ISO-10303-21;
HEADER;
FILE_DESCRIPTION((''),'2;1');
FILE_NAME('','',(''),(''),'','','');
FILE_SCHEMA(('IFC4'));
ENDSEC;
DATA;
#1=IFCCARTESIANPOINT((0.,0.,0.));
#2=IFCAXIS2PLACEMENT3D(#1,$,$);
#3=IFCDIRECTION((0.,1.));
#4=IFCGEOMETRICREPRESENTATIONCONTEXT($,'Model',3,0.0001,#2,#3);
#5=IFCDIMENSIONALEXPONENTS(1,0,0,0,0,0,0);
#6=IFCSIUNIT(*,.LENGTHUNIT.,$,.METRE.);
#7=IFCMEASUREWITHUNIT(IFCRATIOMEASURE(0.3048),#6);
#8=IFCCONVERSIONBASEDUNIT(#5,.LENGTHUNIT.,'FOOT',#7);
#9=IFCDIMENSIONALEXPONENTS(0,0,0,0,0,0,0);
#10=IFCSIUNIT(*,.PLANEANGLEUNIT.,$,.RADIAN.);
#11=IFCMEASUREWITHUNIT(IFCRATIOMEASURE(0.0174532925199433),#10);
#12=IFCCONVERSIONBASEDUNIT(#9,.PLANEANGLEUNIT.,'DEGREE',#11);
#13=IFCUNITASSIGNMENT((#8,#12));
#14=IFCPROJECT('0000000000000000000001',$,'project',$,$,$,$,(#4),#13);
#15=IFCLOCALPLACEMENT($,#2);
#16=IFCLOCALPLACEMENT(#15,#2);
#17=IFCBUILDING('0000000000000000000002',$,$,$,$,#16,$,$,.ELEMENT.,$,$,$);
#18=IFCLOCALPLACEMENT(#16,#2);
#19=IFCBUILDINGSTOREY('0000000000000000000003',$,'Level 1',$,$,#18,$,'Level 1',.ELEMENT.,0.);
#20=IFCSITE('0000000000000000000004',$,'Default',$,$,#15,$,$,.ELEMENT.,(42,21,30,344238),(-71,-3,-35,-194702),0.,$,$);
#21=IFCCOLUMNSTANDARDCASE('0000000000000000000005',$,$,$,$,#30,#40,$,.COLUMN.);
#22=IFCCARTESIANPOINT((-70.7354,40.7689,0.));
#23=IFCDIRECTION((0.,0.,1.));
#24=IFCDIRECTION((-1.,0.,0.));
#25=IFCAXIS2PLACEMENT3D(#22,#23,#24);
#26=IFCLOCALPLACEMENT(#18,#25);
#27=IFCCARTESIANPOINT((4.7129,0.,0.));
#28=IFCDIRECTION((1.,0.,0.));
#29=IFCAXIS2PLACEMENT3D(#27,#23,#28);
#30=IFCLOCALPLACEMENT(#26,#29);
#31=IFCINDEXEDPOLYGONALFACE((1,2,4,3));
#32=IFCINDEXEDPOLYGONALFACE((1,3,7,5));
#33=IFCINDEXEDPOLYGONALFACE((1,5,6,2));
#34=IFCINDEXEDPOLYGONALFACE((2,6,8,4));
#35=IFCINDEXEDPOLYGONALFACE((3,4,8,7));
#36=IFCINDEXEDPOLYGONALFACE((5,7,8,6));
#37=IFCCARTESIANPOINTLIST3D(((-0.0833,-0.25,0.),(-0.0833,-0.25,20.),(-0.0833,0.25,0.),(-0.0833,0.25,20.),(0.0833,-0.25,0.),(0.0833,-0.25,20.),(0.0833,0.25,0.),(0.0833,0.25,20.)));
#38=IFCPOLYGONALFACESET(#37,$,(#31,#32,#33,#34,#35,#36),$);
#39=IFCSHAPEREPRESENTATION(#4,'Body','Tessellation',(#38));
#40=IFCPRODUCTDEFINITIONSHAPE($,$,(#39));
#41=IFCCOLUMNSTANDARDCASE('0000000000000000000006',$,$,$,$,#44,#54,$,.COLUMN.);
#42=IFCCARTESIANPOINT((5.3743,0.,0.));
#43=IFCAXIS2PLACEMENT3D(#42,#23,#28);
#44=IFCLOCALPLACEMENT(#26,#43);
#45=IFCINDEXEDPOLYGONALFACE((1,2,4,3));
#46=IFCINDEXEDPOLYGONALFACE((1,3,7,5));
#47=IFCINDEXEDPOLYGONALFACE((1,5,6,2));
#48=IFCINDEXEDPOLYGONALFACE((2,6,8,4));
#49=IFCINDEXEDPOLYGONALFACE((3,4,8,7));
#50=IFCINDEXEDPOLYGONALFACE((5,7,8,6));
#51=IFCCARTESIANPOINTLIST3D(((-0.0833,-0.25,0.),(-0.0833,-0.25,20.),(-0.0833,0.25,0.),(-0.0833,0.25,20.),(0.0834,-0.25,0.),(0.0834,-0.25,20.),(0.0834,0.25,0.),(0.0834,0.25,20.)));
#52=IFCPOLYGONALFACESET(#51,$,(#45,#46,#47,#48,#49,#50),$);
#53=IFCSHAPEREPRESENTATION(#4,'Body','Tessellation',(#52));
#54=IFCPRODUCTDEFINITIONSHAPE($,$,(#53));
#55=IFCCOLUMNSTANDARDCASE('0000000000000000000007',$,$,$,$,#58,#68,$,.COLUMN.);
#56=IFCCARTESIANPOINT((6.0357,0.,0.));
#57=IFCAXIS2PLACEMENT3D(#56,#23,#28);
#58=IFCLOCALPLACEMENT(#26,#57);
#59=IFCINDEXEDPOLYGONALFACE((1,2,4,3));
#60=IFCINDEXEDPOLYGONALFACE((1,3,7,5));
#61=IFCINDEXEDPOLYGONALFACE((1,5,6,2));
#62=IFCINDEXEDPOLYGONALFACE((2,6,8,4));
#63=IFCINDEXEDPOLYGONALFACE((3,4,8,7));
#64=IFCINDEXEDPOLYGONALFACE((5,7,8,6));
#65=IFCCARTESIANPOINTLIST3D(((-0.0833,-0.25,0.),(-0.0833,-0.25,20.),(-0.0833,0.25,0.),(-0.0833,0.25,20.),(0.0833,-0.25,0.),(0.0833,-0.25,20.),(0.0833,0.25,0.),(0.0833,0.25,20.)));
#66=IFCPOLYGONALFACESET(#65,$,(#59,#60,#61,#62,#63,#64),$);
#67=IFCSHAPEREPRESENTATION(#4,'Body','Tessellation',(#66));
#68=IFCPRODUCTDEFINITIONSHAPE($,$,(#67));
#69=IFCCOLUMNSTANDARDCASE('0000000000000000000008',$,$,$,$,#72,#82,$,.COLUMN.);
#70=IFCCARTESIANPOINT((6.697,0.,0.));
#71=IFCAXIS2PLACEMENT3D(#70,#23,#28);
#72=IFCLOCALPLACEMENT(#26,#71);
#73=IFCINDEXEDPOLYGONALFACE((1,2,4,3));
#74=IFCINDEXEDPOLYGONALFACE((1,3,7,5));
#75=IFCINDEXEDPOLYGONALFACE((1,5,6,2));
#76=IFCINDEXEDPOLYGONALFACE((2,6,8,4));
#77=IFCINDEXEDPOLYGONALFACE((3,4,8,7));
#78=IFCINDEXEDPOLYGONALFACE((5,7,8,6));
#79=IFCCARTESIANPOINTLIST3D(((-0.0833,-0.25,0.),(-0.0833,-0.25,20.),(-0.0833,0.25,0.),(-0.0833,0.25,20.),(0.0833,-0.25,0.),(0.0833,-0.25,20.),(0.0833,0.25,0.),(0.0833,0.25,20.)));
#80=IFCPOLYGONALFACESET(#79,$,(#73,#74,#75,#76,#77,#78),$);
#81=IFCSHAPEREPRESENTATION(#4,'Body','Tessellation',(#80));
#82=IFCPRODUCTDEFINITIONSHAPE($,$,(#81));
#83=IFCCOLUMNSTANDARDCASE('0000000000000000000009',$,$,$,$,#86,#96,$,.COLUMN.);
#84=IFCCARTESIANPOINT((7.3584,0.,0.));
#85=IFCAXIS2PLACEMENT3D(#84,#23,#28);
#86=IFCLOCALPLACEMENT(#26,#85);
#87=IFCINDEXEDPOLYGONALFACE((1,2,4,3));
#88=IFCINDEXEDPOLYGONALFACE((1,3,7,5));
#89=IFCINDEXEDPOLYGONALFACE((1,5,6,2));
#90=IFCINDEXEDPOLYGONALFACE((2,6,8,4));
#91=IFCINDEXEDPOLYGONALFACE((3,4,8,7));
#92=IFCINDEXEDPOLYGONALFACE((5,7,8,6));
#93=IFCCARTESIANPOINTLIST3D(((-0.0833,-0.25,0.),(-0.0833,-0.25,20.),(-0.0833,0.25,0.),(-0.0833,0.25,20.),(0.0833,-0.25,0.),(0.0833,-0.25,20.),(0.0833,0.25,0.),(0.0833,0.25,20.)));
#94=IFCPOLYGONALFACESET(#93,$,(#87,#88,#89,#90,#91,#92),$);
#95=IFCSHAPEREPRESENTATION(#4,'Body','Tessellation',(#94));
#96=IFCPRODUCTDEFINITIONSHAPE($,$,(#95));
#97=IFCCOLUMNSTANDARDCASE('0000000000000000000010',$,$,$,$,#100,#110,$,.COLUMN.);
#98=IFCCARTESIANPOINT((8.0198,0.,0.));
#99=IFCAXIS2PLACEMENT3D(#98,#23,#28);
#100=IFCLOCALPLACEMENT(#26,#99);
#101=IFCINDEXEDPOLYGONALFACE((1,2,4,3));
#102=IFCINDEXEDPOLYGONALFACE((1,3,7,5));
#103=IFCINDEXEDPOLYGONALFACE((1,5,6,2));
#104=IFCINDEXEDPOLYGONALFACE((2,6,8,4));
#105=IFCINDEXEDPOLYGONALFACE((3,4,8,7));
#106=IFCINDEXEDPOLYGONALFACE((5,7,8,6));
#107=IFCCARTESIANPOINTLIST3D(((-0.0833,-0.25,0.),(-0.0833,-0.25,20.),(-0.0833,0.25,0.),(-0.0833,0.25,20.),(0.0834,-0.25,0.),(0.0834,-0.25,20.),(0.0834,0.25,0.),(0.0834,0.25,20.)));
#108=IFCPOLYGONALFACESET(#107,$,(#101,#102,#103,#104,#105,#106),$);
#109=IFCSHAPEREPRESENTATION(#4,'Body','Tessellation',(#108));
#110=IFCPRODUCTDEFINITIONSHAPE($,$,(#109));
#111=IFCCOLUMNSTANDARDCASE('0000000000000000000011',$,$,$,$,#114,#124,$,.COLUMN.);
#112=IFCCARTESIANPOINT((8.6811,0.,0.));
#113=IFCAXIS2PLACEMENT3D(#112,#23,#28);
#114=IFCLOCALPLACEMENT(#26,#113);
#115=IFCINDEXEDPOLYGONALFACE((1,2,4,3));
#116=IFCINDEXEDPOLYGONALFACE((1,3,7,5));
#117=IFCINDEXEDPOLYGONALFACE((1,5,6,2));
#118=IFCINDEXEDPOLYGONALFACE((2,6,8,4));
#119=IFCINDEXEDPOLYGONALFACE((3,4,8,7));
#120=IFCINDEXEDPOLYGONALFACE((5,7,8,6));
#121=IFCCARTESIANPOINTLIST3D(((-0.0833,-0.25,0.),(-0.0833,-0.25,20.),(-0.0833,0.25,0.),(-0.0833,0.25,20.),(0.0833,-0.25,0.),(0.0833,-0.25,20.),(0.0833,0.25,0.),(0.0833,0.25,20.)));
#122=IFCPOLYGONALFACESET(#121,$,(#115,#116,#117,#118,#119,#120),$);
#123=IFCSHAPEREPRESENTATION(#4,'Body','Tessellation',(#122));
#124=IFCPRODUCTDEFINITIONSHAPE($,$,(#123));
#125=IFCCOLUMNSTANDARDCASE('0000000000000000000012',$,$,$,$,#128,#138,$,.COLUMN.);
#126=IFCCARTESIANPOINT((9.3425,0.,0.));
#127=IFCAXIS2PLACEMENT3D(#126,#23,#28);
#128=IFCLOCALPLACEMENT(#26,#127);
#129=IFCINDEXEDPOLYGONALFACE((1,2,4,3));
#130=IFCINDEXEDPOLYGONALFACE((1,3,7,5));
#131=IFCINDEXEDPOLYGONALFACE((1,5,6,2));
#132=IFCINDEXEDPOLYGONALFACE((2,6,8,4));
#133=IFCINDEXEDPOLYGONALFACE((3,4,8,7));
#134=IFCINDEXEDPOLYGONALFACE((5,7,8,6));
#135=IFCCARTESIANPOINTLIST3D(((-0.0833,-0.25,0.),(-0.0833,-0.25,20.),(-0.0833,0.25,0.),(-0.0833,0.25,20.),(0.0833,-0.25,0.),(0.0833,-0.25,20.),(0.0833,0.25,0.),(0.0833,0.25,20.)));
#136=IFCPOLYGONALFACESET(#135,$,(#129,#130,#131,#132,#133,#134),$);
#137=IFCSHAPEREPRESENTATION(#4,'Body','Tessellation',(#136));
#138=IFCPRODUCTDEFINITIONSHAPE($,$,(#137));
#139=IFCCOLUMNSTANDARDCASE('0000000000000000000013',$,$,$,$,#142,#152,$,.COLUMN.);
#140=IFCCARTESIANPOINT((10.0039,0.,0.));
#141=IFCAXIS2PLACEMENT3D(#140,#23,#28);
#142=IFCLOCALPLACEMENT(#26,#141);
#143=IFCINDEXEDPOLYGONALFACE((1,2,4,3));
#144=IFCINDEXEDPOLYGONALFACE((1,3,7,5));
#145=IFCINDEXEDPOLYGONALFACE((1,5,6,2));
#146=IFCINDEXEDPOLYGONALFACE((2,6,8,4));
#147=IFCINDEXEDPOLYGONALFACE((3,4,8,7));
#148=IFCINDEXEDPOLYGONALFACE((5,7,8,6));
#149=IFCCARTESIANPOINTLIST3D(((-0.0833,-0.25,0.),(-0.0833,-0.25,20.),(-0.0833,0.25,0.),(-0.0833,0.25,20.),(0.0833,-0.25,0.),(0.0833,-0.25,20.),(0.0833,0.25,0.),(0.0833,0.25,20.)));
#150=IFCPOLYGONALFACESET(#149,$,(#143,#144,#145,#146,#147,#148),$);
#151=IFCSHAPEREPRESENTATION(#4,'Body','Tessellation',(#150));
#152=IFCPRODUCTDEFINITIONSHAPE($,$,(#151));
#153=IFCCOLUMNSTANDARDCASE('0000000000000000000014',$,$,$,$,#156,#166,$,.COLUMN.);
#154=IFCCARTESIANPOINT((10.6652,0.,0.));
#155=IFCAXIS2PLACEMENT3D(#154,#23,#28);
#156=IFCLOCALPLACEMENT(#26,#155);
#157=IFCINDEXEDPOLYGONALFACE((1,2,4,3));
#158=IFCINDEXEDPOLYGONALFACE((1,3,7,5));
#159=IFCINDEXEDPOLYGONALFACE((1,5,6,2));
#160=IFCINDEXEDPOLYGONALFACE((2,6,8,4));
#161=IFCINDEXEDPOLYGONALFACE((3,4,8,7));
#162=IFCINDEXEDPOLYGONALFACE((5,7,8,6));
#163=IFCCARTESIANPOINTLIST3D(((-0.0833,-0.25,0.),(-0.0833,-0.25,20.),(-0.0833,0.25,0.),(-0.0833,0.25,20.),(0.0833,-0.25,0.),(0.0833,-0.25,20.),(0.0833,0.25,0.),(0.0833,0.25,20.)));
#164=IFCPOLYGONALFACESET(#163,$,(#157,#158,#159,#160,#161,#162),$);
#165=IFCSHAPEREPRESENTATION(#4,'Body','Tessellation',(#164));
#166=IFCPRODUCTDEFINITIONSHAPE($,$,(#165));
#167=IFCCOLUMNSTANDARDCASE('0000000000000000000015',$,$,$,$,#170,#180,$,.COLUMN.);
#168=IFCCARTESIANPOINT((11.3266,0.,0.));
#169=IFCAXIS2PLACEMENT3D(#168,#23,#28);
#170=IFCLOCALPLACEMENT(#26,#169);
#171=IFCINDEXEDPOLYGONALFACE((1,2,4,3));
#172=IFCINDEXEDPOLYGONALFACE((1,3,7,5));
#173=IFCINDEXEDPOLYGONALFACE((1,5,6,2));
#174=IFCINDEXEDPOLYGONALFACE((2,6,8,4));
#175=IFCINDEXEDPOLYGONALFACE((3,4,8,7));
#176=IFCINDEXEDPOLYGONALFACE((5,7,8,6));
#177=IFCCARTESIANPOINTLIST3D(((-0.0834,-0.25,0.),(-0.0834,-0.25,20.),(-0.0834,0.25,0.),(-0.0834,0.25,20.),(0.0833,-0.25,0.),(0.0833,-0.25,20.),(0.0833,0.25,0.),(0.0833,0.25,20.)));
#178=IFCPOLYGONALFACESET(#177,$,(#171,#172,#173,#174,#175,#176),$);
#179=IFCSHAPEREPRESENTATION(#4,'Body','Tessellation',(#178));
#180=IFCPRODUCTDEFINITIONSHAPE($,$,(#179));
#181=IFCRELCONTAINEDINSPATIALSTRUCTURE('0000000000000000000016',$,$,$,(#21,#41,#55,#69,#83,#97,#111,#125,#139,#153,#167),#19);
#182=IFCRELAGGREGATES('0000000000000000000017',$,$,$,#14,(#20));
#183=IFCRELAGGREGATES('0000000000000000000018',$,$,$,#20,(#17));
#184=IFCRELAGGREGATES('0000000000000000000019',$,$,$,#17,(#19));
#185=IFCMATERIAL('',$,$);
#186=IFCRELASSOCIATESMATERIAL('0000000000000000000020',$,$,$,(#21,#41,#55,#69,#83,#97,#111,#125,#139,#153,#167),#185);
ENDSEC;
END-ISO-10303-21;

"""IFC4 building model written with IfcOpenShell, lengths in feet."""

from ifc_helpers import new_model, entity, si_unit, converted_unit, direction, frame, origin, place, context, project, spatial, rectangle, extrude, material, element, save


model = new_model("IFC4")

# Units and contexts
model_context = context("Model", 3, precision=0.0001, world=origin(), true_north=direction((0.0, 1.0)))
ifc_project = project(units=[converted_unit("LENGTHUNIT", "FOOT", entity("IfcRatioMeasure", 0.3048), si_unit("LENGTHUNIT", "METRE"), dimensions=[1, 0, 0, 0, 0, 0, 0]), converted_unit("PLANEANGLEUNIT", "DEGREE", entity("IfcRatioMeasure", 0.0174532925199433), si_unit("PLANEANGLEUNIT", "RADIAN"), dimensions=[0, 0, 0, 0, 0, 0, 0])], contexts=[model_context])

# Site, building, storey
site_placement = place(None, origin())
site = spatial("IfcSite", under=ifc_project, at=site_placement, Name="Default", CompositionType="ELEMENT", RefLatitude=(42, 21, 30, 344238), RefLongitude=(-71, -3, -35, -194702), RefElevation=0.0)
building_placement = place(site_placement, origin())
building = spatial("IfcBuilding", under=site, at=building_placement, CompositionType="ELEMENT")
storey_placement = place(building_placement, origin())
storey = spatial("IfcBuildingStorey", under=building, at=storey_placement, Name="Level 1", LongName="Level 1", CompositionType="ELEMENT", Elevation=0.0)

# Columns
ifc_material_1 = material(Name="")
wall_1_placement = place(storey_placement, frame((-70.7354, 40.7689, 0.0), z_axis=(0.0, 0.0, 1.0), x_axis=(-1.0, 0.0, 0.0)))
for number, where, z_axis, x_axis in (
    (1, (4.7129, 0.0, 0.0), (0.0, 0.0, 1.0), (1.0, 0.0, 0.0)),
    (2, (5.3743, 0.0, 0.0), (0.0, 0.0, 1.0), (1.0, 0.0, 0.0)),
    (3, (6.0357, 0.0, 0.0), (0.0, 0.0, 1.0), (1.0, 0.0, 0.0)),
    (4, (6.697, 0.0, 0.0), (0.0, 0.0, 1.0), (1.0, 0.0, 0.0)),
    (5, (7.3584, 0.0, 0.0), (0.0, 0.0, 1.0), (1.0, 0.0, 0.0)),
    (6, (8.0198, 0.0, 0.0), (0.0, 0.0, 1.0), (1.0, 0.0, 0.0)),
    (7, (8.6811, 0.0, 0.0), (0.0, 0.0, 1.0), (1.0, 0.0, 0.0)),
    (8, (9.3425, 0.0, 0.0), (0.0, 0.0, 1.0), (1.0, 0.0, 0.0)),
    (9, (10.0039, 0.0, 0.0), (0.0, 0.0, 1.0), (1.0, 0.0, 0.0)),
    (10, (10.6652, 0.0, 0.0), (0.0, 0.0, 1.0), (1.0, 0.0, 0.0)),
    (11, (11.3266, 0.0, 0.0), (0.0, 0.0, 1.0), (1.0, 0.0, 0.0)),
):
    element("IfcColumnStandardCase", number, at=place(wall_1_placement, frame(where, z_axis=z_axis, x_axis=x_axis)), inside=storey, material=ifc_material_1, PredefinedType="COLUMN", context=model_context, shape_type="SweptSolid", body=[
        extrude(rectangle(XDim=0.1667, YDim=0.5), origin(), (0.0, 0.0, 1.0), 20.0),
    ])

save(model, "model.ifc")
